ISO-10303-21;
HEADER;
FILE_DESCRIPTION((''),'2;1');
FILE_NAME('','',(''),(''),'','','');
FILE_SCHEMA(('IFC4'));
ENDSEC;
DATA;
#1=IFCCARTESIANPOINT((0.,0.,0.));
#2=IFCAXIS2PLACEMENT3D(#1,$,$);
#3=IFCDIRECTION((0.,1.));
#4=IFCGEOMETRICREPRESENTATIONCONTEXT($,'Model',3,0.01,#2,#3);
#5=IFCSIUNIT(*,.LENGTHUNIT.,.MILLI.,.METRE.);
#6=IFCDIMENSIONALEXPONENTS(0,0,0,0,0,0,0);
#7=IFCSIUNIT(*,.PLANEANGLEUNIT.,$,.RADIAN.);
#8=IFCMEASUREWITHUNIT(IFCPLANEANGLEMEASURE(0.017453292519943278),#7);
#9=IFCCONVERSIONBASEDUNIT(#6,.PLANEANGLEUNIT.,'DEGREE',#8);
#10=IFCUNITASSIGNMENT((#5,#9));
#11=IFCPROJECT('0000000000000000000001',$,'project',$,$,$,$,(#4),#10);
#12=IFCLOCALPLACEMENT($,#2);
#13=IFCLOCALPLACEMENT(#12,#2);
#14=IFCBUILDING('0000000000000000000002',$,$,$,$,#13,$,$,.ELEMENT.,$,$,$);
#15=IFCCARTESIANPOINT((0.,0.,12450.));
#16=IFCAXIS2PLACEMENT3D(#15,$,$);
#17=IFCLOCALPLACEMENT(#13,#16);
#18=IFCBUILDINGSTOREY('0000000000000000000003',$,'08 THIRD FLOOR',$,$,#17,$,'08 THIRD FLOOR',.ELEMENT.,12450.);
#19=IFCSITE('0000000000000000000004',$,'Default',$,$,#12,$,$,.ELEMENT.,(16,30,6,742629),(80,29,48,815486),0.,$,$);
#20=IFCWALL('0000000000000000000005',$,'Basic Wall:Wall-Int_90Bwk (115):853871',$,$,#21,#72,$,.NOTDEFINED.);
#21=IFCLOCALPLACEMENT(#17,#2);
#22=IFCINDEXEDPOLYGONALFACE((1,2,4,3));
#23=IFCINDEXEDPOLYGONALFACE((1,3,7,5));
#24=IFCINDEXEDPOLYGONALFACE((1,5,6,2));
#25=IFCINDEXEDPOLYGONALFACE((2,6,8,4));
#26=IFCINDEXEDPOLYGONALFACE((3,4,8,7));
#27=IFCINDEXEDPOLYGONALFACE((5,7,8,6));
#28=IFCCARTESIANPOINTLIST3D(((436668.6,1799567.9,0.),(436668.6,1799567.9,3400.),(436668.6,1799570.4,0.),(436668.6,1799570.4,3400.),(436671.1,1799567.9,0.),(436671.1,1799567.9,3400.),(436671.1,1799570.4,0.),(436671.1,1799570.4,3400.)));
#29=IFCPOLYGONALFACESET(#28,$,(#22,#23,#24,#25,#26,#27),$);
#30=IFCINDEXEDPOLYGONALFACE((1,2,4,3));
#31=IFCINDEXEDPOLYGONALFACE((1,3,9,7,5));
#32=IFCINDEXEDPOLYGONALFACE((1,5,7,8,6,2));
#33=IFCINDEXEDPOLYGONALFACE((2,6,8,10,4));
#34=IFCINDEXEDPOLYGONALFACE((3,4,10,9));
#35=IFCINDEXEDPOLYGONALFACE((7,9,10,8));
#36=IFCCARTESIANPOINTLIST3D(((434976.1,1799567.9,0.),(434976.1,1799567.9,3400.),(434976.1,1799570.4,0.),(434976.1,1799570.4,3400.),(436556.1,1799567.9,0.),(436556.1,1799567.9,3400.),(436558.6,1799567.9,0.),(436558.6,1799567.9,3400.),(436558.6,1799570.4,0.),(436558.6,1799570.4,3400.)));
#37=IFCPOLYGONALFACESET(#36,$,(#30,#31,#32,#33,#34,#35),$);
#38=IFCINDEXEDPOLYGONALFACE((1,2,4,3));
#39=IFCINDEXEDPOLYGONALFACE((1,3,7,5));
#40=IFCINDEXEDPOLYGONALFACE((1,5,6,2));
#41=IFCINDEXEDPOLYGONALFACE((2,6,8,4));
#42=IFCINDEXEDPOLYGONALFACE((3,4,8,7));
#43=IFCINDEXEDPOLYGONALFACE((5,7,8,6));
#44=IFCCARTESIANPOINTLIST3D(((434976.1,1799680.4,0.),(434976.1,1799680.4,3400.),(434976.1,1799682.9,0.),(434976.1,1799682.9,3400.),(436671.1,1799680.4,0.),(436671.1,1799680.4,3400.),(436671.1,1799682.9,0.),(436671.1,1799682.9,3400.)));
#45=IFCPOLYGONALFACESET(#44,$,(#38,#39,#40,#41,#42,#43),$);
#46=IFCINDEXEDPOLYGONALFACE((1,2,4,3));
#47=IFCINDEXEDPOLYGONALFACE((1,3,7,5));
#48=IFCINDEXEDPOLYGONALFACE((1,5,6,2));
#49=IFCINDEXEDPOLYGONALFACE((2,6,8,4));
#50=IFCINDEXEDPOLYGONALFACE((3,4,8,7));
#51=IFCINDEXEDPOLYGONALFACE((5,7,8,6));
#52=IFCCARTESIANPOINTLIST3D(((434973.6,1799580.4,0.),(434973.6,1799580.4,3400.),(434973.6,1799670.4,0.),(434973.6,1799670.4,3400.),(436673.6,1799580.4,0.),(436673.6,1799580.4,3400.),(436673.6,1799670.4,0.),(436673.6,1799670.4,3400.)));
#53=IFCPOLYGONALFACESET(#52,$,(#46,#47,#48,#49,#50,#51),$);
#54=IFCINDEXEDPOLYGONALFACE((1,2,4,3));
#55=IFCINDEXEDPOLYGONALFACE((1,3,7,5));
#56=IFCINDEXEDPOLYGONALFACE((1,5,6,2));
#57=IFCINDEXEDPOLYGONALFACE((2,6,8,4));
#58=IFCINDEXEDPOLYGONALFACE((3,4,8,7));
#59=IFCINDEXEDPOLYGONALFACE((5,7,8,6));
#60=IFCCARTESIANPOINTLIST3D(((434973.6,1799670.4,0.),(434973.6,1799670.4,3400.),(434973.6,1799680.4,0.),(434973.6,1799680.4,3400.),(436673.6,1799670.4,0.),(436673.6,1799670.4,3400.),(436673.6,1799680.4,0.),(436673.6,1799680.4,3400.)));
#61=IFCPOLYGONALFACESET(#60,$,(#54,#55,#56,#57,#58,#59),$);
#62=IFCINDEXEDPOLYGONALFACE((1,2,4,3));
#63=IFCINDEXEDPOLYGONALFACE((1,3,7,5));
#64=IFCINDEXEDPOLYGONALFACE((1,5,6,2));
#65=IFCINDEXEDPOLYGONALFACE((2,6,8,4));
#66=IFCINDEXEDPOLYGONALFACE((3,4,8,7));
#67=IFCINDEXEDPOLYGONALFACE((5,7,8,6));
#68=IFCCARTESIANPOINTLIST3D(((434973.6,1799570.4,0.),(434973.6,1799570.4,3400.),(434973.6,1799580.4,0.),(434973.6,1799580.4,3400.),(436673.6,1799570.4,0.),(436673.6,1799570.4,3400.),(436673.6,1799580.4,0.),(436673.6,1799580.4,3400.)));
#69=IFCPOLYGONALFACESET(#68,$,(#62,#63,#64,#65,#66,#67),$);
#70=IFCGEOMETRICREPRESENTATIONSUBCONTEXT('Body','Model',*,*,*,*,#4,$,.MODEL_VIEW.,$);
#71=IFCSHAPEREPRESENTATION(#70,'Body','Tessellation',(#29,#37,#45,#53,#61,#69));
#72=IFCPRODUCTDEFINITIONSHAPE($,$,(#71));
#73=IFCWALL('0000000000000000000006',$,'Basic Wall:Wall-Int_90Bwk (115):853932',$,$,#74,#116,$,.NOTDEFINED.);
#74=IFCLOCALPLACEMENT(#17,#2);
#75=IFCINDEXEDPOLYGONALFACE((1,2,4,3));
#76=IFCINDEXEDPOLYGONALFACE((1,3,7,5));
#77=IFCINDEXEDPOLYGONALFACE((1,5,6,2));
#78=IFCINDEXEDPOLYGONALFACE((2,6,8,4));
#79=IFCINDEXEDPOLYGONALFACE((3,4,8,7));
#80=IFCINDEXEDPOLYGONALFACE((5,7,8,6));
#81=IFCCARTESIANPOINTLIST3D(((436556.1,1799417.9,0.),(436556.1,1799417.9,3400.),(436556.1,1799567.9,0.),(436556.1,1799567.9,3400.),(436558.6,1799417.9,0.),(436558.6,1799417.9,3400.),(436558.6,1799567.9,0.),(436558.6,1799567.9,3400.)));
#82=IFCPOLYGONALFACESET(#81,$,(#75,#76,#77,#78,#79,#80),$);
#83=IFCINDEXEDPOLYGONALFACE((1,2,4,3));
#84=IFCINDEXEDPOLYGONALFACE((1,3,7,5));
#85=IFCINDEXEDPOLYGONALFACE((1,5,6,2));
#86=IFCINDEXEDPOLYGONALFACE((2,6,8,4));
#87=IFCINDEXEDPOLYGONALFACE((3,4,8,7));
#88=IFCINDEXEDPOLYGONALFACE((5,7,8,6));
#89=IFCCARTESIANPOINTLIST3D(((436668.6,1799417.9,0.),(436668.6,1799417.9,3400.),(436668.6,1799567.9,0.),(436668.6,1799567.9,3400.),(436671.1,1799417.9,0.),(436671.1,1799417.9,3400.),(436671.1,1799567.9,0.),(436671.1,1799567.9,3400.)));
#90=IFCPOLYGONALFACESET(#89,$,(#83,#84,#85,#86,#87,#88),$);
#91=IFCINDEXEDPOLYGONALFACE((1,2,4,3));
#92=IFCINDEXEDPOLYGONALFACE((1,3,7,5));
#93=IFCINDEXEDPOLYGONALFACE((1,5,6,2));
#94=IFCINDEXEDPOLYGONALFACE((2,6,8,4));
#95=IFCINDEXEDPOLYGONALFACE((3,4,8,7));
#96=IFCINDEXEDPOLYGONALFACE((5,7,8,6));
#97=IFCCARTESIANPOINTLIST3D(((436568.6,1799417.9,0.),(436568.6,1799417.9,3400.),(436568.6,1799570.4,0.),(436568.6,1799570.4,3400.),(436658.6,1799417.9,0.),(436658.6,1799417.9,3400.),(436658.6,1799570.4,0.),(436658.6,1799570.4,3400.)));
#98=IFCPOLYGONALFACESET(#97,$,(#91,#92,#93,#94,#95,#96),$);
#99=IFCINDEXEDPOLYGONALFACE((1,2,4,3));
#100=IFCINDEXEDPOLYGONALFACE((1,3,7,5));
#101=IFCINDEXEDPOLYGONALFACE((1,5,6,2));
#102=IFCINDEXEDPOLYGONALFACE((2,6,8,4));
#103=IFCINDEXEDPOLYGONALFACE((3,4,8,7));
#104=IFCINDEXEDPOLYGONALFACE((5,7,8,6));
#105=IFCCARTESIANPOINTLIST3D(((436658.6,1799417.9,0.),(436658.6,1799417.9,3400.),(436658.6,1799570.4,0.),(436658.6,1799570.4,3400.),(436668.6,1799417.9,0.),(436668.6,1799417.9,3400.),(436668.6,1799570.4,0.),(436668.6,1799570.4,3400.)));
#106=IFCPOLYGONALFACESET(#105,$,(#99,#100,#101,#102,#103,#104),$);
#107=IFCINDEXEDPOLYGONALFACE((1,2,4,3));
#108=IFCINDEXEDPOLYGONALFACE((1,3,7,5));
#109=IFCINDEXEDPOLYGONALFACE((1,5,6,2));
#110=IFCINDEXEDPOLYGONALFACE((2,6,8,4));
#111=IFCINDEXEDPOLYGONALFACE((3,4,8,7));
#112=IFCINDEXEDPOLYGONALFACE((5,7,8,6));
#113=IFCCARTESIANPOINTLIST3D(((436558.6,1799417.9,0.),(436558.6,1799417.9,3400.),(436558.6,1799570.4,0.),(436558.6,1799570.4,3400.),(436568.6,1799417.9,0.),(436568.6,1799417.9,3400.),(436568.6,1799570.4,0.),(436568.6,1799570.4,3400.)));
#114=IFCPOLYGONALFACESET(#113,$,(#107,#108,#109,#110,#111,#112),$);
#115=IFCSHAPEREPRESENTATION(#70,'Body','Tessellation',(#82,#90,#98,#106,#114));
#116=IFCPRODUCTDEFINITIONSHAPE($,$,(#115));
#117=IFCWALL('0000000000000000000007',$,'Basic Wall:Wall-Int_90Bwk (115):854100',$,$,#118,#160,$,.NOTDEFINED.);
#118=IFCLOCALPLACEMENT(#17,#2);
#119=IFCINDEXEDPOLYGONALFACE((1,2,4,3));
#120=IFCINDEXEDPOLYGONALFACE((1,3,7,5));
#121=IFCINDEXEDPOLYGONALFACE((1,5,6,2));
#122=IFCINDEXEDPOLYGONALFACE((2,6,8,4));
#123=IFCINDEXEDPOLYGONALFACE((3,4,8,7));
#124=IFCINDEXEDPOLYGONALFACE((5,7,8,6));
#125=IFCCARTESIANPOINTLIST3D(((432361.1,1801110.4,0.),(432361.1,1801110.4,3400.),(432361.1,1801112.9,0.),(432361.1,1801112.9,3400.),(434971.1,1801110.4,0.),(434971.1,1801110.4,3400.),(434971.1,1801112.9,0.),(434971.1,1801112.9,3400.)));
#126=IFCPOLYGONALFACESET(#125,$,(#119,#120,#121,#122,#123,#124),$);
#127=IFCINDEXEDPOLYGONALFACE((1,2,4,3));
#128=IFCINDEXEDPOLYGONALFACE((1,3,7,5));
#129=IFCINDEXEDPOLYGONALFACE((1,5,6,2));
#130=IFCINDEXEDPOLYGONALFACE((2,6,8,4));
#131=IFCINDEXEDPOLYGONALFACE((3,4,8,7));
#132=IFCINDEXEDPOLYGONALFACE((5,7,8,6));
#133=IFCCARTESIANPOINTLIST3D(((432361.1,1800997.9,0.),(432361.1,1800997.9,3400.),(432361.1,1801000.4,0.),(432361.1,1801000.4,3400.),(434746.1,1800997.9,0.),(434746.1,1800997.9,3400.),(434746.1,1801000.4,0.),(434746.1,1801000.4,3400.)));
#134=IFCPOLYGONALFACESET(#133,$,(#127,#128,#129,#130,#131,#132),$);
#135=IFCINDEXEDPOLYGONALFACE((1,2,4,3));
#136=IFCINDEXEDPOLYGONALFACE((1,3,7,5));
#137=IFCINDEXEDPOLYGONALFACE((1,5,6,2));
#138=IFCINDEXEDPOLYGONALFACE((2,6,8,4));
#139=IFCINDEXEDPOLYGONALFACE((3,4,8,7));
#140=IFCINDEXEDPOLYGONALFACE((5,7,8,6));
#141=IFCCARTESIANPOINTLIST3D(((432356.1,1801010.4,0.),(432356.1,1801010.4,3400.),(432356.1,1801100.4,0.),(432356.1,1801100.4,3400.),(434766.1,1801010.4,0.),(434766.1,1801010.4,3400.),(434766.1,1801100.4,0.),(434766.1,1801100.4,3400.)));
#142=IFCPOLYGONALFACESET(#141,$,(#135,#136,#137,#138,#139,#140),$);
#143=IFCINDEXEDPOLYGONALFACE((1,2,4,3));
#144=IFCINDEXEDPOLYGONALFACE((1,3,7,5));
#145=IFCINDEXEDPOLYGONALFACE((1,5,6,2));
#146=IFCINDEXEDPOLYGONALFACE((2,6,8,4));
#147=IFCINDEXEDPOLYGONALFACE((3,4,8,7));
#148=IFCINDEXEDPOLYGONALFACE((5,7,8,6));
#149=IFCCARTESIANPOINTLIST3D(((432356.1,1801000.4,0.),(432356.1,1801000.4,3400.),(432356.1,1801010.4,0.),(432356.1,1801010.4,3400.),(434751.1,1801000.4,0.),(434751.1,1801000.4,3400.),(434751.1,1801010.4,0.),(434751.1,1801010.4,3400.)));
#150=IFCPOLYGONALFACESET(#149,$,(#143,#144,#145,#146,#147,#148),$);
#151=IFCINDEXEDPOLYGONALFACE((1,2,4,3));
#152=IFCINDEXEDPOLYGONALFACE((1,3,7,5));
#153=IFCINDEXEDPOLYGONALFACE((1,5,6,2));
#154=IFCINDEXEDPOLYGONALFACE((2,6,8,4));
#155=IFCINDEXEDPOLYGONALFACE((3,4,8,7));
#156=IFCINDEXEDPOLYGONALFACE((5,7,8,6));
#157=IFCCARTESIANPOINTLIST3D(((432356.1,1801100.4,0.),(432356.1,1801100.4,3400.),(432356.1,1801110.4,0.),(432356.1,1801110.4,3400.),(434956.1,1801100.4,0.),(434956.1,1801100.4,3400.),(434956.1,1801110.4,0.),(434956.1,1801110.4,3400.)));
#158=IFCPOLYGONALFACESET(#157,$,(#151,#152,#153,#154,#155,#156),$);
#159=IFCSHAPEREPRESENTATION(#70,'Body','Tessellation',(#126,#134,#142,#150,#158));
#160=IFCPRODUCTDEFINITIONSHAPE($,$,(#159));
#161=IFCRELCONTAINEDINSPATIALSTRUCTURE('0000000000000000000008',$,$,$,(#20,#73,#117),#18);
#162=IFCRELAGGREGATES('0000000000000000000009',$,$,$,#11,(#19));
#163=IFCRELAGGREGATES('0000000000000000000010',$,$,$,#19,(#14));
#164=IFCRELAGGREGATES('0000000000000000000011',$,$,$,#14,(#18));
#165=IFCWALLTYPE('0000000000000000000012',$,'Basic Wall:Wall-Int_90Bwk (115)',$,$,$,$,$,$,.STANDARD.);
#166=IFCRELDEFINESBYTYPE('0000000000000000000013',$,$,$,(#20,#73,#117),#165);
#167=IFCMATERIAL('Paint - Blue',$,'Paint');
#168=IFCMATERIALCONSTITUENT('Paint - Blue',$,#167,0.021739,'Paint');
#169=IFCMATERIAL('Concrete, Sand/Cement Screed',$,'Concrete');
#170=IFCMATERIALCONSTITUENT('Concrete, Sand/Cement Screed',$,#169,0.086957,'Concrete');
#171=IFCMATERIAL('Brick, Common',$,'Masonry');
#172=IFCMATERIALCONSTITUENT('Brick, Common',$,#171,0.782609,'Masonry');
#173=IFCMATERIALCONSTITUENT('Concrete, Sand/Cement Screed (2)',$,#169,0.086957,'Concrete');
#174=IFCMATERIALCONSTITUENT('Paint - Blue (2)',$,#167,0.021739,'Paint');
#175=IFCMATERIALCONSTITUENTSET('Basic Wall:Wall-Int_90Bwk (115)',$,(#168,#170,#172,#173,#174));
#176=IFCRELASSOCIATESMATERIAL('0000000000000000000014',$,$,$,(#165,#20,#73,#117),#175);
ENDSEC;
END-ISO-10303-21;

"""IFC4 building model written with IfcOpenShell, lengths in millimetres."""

from ifc_helpers import new_model, entity, si_unit, converted_unit, direction, frame, origin, place, context, subcontext, project, spatial, indexed_curve, outline, extrude, material, constituent, constituent_set, type_object, element, save


model = new_model("IFC4")

# Units and contexts
model_context = context("Model", 3, precision=0.01, world=origin(), true_north=direction((0.0, 1.0)))
body_context = subcontext(model_context, "Body", "Model", "MODEL_VIEW")
ifc_project = project(units=[si_unit("LENGTHUNIT", "METRE", prefix="MILLI"), converted_unit("PLANEANGLEUNIT", "DEGREE", entity("IfcPlaneAngleMeasure", 0.017453292519943278), si_unit("PLANEANGLEUNIT", "RADIAN"), dimensions=[0, 0, 0, 0, 0, 0, 0])], contexts=[model_context])

# Site, building, storey
site_placement = place(None, origin())
site = spatial("IfcSite", under=ifc_project, at=site_placement, Name="Default", CompositionType="ELEMENT", RefLatitude=(16, 30, 6, 742629), RefLongitude=(80, 29, 48, 815486), RefElevation=0.0)
building_placement = place(site_placement, origin())
building = spatial("IfcBuilding", under=site, at=building_placement, CompositionType="ELEMENT")
storey_placement = place(building_placement, frame((0.0, 0.0, 12450.0)))
storey = spatial("IfcBuildingStorey", under=building, at=storey_placement, Name="08 THIRD FLOOR", LongName="08 THIRD FLOOR", CompositionType="ELEMENT", Elevation=12450.0)

# Shared definitions
ifc_material_1 = material(Name="Paint - Blue", Category="Paint")
ifc_constituent_1 = constituent(ifc_material_1, Name="Paint - Blue", Category="Paint", fraction=0.021739)
ifc_material_2 = material(Name="Concrete, Sand/Cement Screed", Category="Concrete")
ifc_constituent_2 = constituent(ifc_material_2, Name="Concrete, Sand/Cement Screed", Category="Concrete", fraction=0.086957)
ifc_material_3 = material(Name="Brick, Common", Category="Masonry")
ifc_constituent_3 = constituent(ifc_material_3, Name="Brick, Common", Category="Masonry", fraction=0.782609)
ifc_constituent_4 = constituent(ifc_material_2, Name="Concrete, Sand/Cement Screed (2)", Category="Concrete", fraction=0.086957)
ifc_constituent_5 = constituent(ifc_material_1, Name="Paint - Blue (2)", Category="Paint", fraction=0.021739)
ifc_constituent_set_1 = constituent_set(constituents=[ifc_constituent_1, ifc_constituent_2, ifc_constituent_3, ifc_constituent_4, ifc_constituent_5], Name="Basic Wall:Wall-Int_90Bwk (115)")
wall_type_1 = type_object("IfcWallType", Name="Basic Wall:Wall-Int_90Bwk (115)", PredefinedType="STANDARD", material=ifc_constituent_set_1)

# Walls
wall_1_placement = place(storey_placement, frame((434976.1, 1799625.4, 0.0)))
element("IfcWall", 1, at=wall_1_placement, inside=storey, type_object=wall_type_1, material=ifc_constituent_set_1, Name="Basic Wall:Wall-Int_90Bwk (115):853871", PredefinedType="NOTDEFINED", context=body_context, shape_type="SweptSolid", body=[
    extrude(outline(indexed_curve([(-1.2, -1.2), (1.3, -1.2), (1.3, 1.3), (-1.2, 1.3), (-1.2, -1.2)], self_intersect=False)), frame((1693.7, -56.2, 0.0), z_axis=(0.0, 0.0, 1.0), x_axis=(-1.0, 0.0, 0.0)), (0.0, 0.0, 1.0), 3400.0),
    extrude(outline(indexed_curve([(631.0, -1.0), (633.5, -1.0), (633.5, 1.5), (-949.0, 1.5), (-949.0, -1.0), (631.0, -1.0)], self_intersect=False)), frame((949.0, -56.5, 0.0)), (0.0, 0.0, 1.0), 3400.0),
    extrude(outline(indexed_curve([(-1.3, -847.5), (1.3, -847.5), (1.3, 847.5), (-1.3, 847.5), (-1.3, -847.5)], self_intersect=False)), frame((847.5, 56.3, 0.0), z_axis=(0.0, 0.0, 1.0), x_axis=(0.0, -1.0, 0.0)), (0.0, 0.0, 1.0), 3400.0),
    extrude(outline(indexed_curve([(-850.0, -45.0), (850.0, -45.0), (850.0, 45.0), (-850.0, 45.0), (-850.0, -45.0)], self_intersect=False)), frame((847.5, 0.0, 0.0)), (0.0, 0.0, 1.0), 3400.0),
    extrude(outline(indexed_curve([(-850.0, -5.0), (850.0, -5.0), (850.0, 5.0), (-850.0, 5.0), (-850.0, -5.0)], self_intersect=False)), frame((847.5, 50.0, 0.0)), (0.0, 0.0, 1.0), 3400.0),
    extrude(outline(indexed_curve([(-850.0, -5.0), (850.0, -5.0), (850.0, 5.0), (-850.0, 5.0), (-850.0, -5.0)], self_intersect=False)), frame((847.5, -50.0, 0.0)), (0.0, 0.0, 1.0), 3400.0),
])
wall_2_placement = place(storey_placement, frame((436613.6, 1799417.9, 0.0), z_axis=(0.0, 0.0, 1.0), x_axis=(0.0, 1.0, 0.0)))
element("IfcWall", 2, at=wall_2_placement, inside=storey, type_object=wall_type_1, material=ifc_constituent_set_1, Name="Basic Wall:Wall-Int_90Bwk (115):853932", PredefinedType="NOTDEFINED", context=body_context, shape_type="SweptSolid", body=[
    extrude(outline(indexed_curve([(-1.3, -75.0), (1.2, -75.0), (1.2, 75.0), (-1.3, 75.0), (-1.3, -75.0)], self_intersect=False)), frame((75.0, 56.2, 0.0), z_axis=(0.0, 0.0, 1.0), x_axis=(0.0, -1.0, 0.0)), (0.0, 0.0, 1.0), 3400.0),
    extrude(outline(indexed_curve([(-1.2, -75.0), (1.3, -75.0), (1.3, 75.0), (-1.2, 75.0), (-1.2, -75.0)], self_intersect=False)), frame((75.0, -56.3, 0.0), z_axis=(0.0, 0.0, 1.0), x_axis=(0.0, 1.0, 0.0)), (0.0, 0.0, 1.0), 3400.0),
    extrude(outline(indexed_curve([(-76.2, -45.0), (76.2, -45.0), (76.2, 45.0), (-76.2, 45.0), (-76.2, -45.0)], self_intersect=False)), frame((76.2, 0.0, 0.0)), (0.0, 0.0, 1.0), 3400.0),
    extrude(outline(indexed_curve([(-76.2, -5.0), (76.2, -5.0), (76.2, 5.0), (-76.2, 5.0), (-76.2, -5.0)], self_intersect=False)), frame((76.2, -50.0, 0.0)), (0.0, 0.0, 1.0), 3400.0),
    extrude(outline(indexed_curve([(-76.2, -5.0), (76.2, -5.0), (76.2, 5.0), (-76.2, 5.0), (-76.2, -5.0)], self_intersect=False)), frame((76.2, 50.0, 0.0)), (0.0, 0.0, 1.0), 3400.0),
])
wall_3_placement = place(storey_placement, frame((432361.1, 1801055.4, 0.0)))
element("IfcWall", 3, at=wall_3_placement, inside=storey, type_object=wall_type_1, material=ifc_constituent_set_1, Name="Basic Wall:Wall-Int_90Bwk (115):854100", PredefinedType="NOTDEFINED", context=body_context, shape_type="SweptSolid", body=[
    extrude(outline(indexed_curve([(-1.2, -1305.0), (1.3, -1305.0), (1.3, 1305.0), (-1.2, 1305.0), (-1.2, -1305.0)], self_intersect=False)), frame((1305.0, 56.3, 0.0), z_axis=(0.0, 0.0, 1.0), x_axis=(0.0, -1.0, 0.0)), (0.0, 0.0, 1.0), 3400.0),
    extrude(outline(indexed_curve([(-1.2, -1192.5), (1.3, -1192.5), (1.3, 1192.5), (-1.2, 1192.5), (-1.2, -1192.5)], self_intersect=False)), frame((1192.5, -56.3, 0.0), z_axis=(0.0, 0.0, 1.0), x_axis=(0.0, 1.0, 0.0)), (0.0, 0.0, 1.0), 3400.0),
    extrude(outline(indexed_curve([(-1205.0, -45.0), (1205.0, -45.0), (1205.0, 45.0), (-1205.0, 45.0), (-1205.0, -45.0)], self_intersect=False)), frame((1200.0, 0.0, 0.0)), (0.0, 0.0, 1.0), 3400.0),
    extrude(outline(indexed_curve([(-1197.5, -5.0), (1197.5, -5.0), (1197.5, 5.0), (-1197.5, 5.0), (-1197.5, -5.0)], self_intersect=False)), frame((1192.5, -50.0, 0.0)), (0.0, 0.0, 1.0), 3400.0),
    extrude(outline(indexed_curve([(-1300.0, -5.0), (1300.0, -5.0), (1300.0, 5.0), (-1300.0, 5.0), (-1300.0, -5.0)], self_intersect=False)), frame((1295.0, 50.0, 0.0)), (0.0, 0.0, 1.0), 3400.0),
])

save(model, "model.ifc")
